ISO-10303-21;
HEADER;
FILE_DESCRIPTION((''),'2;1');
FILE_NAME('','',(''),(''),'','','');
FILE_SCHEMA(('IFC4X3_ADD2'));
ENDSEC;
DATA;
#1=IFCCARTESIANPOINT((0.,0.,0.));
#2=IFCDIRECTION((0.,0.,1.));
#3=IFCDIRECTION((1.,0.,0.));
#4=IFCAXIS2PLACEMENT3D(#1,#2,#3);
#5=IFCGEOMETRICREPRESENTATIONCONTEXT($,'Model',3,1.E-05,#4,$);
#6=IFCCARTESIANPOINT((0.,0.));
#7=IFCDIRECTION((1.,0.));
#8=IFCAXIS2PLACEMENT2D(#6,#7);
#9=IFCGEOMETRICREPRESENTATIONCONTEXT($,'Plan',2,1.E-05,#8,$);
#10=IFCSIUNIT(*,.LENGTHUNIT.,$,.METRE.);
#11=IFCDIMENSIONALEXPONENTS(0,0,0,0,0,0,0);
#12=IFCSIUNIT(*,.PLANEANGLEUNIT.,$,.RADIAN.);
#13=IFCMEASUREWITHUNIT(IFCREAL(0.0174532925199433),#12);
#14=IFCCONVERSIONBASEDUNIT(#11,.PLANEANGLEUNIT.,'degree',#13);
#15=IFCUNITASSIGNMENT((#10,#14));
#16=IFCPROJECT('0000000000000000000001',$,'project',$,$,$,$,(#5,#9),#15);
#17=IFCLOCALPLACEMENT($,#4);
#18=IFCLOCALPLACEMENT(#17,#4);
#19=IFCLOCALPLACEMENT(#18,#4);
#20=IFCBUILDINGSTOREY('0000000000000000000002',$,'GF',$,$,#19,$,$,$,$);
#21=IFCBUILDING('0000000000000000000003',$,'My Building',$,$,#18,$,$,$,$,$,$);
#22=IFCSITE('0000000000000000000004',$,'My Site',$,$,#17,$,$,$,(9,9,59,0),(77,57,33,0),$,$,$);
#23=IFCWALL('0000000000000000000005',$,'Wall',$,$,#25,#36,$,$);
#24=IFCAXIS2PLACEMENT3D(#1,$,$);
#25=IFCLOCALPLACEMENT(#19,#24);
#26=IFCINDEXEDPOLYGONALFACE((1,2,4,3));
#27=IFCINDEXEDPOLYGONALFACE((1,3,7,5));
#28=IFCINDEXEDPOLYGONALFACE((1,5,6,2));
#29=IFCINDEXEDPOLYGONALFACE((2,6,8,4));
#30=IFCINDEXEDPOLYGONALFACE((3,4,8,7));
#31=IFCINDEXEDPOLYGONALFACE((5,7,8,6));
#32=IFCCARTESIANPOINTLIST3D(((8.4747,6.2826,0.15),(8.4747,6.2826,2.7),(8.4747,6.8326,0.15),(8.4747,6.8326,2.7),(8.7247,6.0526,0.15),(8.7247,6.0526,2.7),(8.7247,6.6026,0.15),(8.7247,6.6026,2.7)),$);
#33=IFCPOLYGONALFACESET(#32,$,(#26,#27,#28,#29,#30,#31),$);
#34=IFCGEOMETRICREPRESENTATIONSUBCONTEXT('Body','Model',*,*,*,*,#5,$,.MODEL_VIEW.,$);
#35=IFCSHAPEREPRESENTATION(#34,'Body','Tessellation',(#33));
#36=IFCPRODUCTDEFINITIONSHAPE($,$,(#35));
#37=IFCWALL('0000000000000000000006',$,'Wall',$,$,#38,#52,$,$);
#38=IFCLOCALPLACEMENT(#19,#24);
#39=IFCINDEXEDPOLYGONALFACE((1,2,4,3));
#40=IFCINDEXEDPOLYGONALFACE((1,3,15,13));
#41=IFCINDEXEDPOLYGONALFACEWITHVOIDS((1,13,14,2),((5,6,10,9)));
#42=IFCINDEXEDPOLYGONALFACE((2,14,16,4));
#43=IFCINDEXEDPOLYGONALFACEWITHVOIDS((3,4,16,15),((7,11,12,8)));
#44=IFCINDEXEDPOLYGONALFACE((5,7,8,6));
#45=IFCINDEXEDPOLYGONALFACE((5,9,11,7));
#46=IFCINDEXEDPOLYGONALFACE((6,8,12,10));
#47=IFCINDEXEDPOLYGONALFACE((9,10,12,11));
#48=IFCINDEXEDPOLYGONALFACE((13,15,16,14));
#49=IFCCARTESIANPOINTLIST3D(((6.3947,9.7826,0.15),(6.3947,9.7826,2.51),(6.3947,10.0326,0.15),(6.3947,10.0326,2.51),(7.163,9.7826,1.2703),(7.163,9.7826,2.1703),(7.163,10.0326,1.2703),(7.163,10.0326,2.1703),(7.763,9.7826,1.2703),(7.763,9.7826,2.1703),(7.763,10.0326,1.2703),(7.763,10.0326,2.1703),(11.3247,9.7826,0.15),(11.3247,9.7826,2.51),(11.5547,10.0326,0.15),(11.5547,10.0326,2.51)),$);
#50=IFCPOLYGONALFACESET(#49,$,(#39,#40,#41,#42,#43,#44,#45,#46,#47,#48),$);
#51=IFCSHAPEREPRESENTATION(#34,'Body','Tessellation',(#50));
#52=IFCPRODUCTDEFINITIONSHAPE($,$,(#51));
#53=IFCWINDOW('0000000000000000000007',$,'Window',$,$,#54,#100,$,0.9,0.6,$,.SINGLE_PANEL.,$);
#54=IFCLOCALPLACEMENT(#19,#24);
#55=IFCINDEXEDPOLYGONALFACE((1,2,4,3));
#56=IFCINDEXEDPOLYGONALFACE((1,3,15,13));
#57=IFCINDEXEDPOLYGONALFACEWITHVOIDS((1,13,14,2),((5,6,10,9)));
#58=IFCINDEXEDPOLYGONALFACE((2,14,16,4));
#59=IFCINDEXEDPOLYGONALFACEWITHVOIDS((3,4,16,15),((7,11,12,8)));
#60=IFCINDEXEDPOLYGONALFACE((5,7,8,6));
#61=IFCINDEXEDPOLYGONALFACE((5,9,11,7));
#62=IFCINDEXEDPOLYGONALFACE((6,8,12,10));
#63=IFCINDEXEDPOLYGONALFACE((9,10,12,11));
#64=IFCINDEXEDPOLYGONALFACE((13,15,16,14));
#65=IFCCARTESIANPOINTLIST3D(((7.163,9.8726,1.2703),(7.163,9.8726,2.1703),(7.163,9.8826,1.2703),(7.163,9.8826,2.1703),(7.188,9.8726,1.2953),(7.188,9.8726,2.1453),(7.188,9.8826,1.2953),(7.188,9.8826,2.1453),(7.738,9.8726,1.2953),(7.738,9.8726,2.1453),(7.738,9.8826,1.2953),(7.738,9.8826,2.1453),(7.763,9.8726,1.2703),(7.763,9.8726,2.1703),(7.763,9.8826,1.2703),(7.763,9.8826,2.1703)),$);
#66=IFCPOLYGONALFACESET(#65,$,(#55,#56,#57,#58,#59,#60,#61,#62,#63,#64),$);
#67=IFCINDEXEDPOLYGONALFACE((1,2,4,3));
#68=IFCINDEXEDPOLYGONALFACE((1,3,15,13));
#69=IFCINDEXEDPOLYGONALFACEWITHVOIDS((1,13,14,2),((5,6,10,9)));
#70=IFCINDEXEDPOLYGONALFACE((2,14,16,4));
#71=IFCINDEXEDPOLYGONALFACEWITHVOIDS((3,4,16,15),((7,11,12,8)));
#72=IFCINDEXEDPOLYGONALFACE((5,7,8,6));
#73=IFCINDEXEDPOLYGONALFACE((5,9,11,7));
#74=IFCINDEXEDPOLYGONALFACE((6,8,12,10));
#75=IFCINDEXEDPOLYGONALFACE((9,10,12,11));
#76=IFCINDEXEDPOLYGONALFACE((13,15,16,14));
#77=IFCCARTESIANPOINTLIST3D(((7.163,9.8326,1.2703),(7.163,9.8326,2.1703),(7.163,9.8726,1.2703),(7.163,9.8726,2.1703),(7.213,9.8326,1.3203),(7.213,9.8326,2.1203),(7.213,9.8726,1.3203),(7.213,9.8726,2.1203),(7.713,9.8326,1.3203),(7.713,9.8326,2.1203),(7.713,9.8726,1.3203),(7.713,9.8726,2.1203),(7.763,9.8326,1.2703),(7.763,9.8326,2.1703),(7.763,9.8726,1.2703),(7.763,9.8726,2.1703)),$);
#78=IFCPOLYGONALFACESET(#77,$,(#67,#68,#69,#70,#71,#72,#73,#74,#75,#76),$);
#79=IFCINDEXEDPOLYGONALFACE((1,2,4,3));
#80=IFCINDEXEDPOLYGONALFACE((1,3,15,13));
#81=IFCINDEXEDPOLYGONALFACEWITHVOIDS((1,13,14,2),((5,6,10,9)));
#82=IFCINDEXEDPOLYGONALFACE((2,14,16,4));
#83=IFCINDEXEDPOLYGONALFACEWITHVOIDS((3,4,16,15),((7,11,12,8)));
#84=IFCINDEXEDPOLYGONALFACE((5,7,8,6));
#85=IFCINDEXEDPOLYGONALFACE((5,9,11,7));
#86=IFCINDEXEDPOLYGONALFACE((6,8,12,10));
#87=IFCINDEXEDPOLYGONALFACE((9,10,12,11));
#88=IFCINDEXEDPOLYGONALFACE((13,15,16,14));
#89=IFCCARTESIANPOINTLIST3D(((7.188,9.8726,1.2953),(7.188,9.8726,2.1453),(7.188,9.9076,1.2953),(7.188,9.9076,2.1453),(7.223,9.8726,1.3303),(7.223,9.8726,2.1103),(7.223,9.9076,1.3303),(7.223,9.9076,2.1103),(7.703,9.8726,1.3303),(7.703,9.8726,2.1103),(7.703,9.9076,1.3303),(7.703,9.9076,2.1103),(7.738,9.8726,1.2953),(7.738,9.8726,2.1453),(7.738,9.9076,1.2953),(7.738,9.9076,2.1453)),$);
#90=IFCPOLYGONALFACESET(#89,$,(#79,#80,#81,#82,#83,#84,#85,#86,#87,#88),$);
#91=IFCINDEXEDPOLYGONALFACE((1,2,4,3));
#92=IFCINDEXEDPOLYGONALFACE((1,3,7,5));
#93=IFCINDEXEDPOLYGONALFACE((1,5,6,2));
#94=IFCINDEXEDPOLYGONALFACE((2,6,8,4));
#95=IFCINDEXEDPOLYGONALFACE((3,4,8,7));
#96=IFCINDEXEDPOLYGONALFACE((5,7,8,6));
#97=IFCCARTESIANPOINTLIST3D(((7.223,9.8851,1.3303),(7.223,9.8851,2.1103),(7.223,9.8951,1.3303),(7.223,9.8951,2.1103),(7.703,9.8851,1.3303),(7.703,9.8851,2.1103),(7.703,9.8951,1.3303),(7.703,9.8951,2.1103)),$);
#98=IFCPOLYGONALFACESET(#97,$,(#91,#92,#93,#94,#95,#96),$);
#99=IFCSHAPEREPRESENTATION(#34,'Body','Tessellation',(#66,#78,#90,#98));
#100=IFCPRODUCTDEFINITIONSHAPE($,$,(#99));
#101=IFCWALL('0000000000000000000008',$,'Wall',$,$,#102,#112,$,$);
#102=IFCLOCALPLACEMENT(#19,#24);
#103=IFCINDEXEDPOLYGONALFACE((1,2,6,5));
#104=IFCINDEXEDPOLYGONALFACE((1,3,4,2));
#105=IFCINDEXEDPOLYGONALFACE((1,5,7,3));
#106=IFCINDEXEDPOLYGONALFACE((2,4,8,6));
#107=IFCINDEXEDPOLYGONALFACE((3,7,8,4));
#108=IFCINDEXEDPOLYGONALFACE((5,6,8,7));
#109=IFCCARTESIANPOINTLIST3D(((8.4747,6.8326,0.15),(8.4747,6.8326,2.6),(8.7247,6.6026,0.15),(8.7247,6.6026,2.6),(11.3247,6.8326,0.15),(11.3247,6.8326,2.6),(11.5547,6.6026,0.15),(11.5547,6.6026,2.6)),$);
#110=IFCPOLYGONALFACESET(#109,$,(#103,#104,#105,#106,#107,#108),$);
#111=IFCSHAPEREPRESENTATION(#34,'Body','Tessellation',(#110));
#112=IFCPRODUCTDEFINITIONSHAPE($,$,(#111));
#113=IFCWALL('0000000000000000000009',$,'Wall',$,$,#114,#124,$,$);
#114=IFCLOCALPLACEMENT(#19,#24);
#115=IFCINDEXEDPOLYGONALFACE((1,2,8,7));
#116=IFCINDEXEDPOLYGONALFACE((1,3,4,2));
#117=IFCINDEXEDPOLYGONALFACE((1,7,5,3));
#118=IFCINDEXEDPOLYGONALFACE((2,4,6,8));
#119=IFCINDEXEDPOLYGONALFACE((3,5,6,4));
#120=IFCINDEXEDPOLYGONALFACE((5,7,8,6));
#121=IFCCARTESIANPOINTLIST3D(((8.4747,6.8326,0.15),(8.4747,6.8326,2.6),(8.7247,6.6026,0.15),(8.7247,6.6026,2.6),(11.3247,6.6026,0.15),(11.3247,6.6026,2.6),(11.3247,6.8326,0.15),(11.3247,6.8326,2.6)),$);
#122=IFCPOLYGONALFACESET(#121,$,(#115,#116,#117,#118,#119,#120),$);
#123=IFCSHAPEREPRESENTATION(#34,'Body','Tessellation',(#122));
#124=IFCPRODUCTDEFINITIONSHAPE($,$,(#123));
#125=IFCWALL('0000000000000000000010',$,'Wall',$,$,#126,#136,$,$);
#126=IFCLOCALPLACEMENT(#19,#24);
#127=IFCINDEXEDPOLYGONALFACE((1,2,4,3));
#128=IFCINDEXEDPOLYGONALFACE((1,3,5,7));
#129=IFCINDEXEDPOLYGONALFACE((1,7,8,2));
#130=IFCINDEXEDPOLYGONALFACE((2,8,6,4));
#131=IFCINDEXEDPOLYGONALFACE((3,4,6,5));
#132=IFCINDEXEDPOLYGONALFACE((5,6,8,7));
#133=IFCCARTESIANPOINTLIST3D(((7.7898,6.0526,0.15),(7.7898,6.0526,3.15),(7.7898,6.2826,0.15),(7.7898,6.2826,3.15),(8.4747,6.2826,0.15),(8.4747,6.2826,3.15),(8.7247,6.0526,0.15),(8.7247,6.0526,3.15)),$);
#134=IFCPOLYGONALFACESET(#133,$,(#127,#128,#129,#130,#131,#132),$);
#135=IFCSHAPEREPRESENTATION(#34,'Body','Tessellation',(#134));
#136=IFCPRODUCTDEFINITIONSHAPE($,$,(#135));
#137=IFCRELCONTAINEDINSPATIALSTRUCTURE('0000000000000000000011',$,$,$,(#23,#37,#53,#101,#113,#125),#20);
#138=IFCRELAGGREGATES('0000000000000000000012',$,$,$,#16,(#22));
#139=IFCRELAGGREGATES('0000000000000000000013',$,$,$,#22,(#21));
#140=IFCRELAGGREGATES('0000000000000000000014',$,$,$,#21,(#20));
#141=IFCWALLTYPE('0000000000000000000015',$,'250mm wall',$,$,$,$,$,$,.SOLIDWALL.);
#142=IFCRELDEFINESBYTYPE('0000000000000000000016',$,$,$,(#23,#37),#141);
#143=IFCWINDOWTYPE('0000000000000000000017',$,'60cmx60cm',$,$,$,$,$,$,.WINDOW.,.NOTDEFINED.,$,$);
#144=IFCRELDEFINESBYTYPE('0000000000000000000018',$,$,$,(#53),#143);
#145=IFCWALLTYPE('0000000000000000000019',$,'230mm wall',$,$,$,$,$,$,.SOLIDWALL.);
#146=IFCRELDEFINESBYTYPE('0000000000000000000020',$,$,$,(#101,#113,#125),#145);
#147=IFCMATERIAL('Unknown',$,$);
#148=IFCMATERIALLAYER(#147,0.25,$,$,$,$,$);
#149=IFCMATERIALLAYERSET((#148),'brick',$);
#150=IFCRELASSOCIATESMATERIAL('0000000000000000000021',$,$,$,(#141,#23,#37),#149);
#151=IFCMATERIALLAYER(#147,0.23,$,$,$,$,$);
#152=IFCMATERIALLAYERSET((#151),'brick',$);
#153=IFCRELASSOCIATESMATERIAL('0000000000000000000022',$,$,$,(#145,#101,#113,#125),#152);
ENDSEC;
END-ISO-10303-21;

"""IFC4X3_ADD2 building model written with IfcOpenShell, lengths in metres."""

from ifc_helpers import new_model, entity, si_unit, converted_unit, frame, origin_with_axes, origin_2d_with_axis, place, context, subcontext, project, spatial, line, indexed_curve, outline, extrude, shape, source, transform, mapped, material, layer, layer_set, layer_usage, type_object, type_shapes, element, fill, save


model = new_model("IFC4X3_ADD2")

# Units and contexts
model_context = context("Model", 3, precision=1e-05, world=origin_with_axes())
plan_context = context("Plan", 2, precision=1e-05, world=origin_2d_with_axis())
body_context_1 = subcontext(model_context, "Body", "Model", "MODEL_VIEW")
body_context_2 = subcontext(plan_context, "Body", "Plan", "PLAN_VIEW")
ifc_project = project(units=[si_unit("LENGTHUNIT", "METRE"), converted_unit("PLANEANGLEUNIT", "degree", entity("IfcReal", 0.0174532925199433), si_unit("PLANEANGLEUNIT", "RADIAN"), dimensions=[0, 0, 0, 0, 0, 0, 0])], contexts=[model_context, plan_context])

# Site, building, storey
site_placement = place(None, origin_with_axes())
site = spatial("IfcSite", under=ifc_project, at=site_placement, Name="My Site", RefLatitude=(9, 9, 59, 0), RefLongitude=(77, 57, 33, 0))
building_placement = place(site_placement, origin_with_axes())
building = spatial("IfcBuilding", under=site, at=building_placement, Name="My Building")
storey_placement = place(building_placement, origin_with_axes())
storey = spatial("IfcBuildingStorey", under=building, at=storey_placement, Name="GF")

# Shared definitions
ifc_material = material(Name="Unknown")
ifc_layer_1 = layer(ifc_material, 0.25)
ifc_layer_set_1 = layer_set([ifc_layer_1], Name="brick")
wall_type_1 = type_object("IfcWallType", Name="250mm wall", PredefinedType="SOLIDWALL", material=ifc_layer_set_1)
wall_1_placement = place(storey_placement, frame((6.3947, 9.7826, 0.15), z_axis=(0.0, 0.0, 1.0), x_axis=(1.0, 0.0, 0.0)))
shared_shape_1 = source(origin_with_axes(), body_context_1, "Body", "SweptSolid", [
    extrude(outline(indexed_curve([(0.0, 0.0), (0.6, 0.0), (0.6, 0.9), (0.0, 0.9)], segments=[line(1, 2, 3, 4, 1)])), frame((0.0, -0.6, 0.0), z_axis=(0.0, -1.0, 0.0), x_axis=(1.0, 0.0, 0.0)), (0.0, 0.0, -1.0), 1.2),
])
window_type_1 = type_object("IfcWindowType", Name="60cmx60cm", PartitioningType="NOTDEFINED", PredefinedType="WINDOW")
shared_shape_2 = source(origin_with_axes(), body_context_1, "Body", "SweptSolid", [
    extrude(outline(indexed_curve([(0.0, 0.0), (0.6, 0.0), (0.6, 0.9), (0.0, 0.9)], segments=[line(1, 2, 3, 4, 1)]), holes=[indexed_curve([(0.025, 0.025), (0.575, 0.025), (0.575, 0.875), (0.025, 0.875)], segments=[line(1, 2, 3, 4, 1)])]), frame((0.0, 0.09, 0.0), z_axis=(0.0, -1.0, 0.0), x_axis=(1.0, 0.0, 0.0)), (0.0, 0.0, -1.0), 0.01),
    extrude(outline(indexed_curve([(0.0, 0.0), (0.6, 0.0), (0.6, 0.9), (0.0, 0.9)], segments=[line(1, 2, 3, 4, 1)]), holes=[indexed_curve([(0.05, 0.05), (0.55, 0.05), (0.55, 0.85), (0.05, 0.85)], segments=[line(1, 2, 3, 4, 1)])]), frame((0.0, 0.05, 0.0), z_axis=(0.0, -1.0, 0.0), x_axis=(1.0, 0.0, 0.0)), (0.0, 0.0, -1.0), 0.04),
    extrude(outline(indexed_curve([(0.0, 0.0), (0.55, 0.0), (0.55, 0.85), (0.0, 0.85)], segments=[line(1, 2, 3, 4, 1)]), holes=[indexed_curve([(0.035, 0.035), (0.515, 0.035), (0.515, 0.815), (0.035, 0.815)], segments=[line(1, 2, 3, 4, 1)])]), frame((0.025, 0.09, 0.025), z_axis=(0.0, -1.0, 0.0), x_axis=(1.0, 0.0, 0.0)), (0.0, 0.0, -1.0), 0.035),
    extrude(outline(indexed_curve([(0.035, 0.035), (0.515, 0.035), (0.515, 0.815), (0.035, 0.815)], segments=[line(1, 2, 3, 4, 1)])), frame((0.025, 0.1025, 0.025), z_axis=(0.0, -1.0, 0.0), x_axis=(1.0, 0.0, 0.0)), (0.0, 0.0, -1.0), 0.01),
])
shared_shape_3 = source(origin_with_axes(), body_context_2, "Body", "Curve2D", [
    entity("IfcIndexedPolyCurve", entity("IfcCartesianPointList2D", [[0.05, 0.05], [0.55, 0.05]])),
    entity("IfcIndexedPolyCurve", entity("IfcCartesianPointList2D", [[0.0, 0.1], [0.025, 0.1], [0.025, 0.09], [0.05, 0.09], [0.05, 0.05], [0.0, 0.05]]), [entity("IfcLineIndex", [1, 2, 3, 4, 5, 6, 1])]),
    entity("IfcIndexedPolyCurve", entity("IfcCartesianPointList2D", [[0.6, 0.1], [0.575, 0.1], [0.575, 0.09], [0.55, 0.09], [0.55, 0.05], [0.6, 0.05]]), [entity("IfcLineIndex", [1, 2, 3, 4, 5, 6, 1])]),
    entity("IfcIndexedPolyCurve", entity("IfcCartesianPointList2D", [[0.025, 0.09], [0.06, 0.09], [0.06, 0.125], [0.025, 0.125]]), [entity("IfcLineIndex", [1, 2, 3, 4, 1])]),
    entity("IfcIndexedPolyCurve", entity("IfcCartesianPointList2D", [[0.575, 0.09], [0.54, 0.09], [0.54, 0.125], [0.575, 0.125]]), [entity("IfcLineIndex", [1, 2, 3, 4, 1])]),
    entity("IfcIndexedPolyCurve", entity("IfcCartesianPointList2D", [[0.06, 0.09], [0.54, 0.09]])),
    entity("IfcIndexedPolyCurve", entity("IfcCartesianPointList2D", [[0.06, 0.125], [0.54, 0.125]])),
    entity("IfcIndexedPolyCurve", entity("IfcCartesianPointList2D", [[0.06, 0.1075], [0.54, 0.1075]])),
])
type_shapes(window_type_1, [shared_shape_2, shared_shape_3])
placement = place(wall_1_placement, frame((0.7684, 0.0, 1.1203), z_axis=(0.0, 0.0, 1.0), x_axis=(1.0, 0.0, 0.0)))

# Wall
ifc_layer_usage_1 = layer_usage(ifc_layer_set_1, "AXIS2", "POSITIVE", 0.0)
wall_2_placement = place(storey_placement, frame((8.7247, 6.0526, 0.15), z_axis=(0.0, 0.0, 1.0), x_axis=(0.0, 1.0, 0.0)))
element("IfcWall", 1, at=wall_2_placement, inside=storey, type_object=wall_type_1, material=ifc_layer_usage_1, Name="Wall", context=body_context_1, shape_type="SweptSolid", body=[
    extrude(outline(indexed_curve([(0.0, 0.0), (0.23, 0.25), (0.78, 0.25), (0.55, 0.0)], segments=[line(1, 2, 3, 4, 1)])), origin_with_axes(), (0.0, 0.0, 1.0), 2.55),
])

# Wall, opening, window
ifc_layer_usage_2 = layer_usage(ifc_layer_set_1, "AXIS2", "POSITIVE", 0.0)
wall_3_placement = place(storey_placement, frame((6.3947, 9.7826, 0.15), z_axis=(0.0, 0.0, 1.0), x_axis=(1.0, 0.0, 0.0)))
wall_3 = element("IfcWall", 2, at=wall_3_placement, inside=storey, type_object=wall_type_1, material=ifc_layer_usage_2, Name="Wall", context=body_context_1, shape_type="SweptSolid", body=[
    extrude(outline(indexed_curve([(0.0, 0.0), (0.0, 0.25), (5.16, 0.25), (4.93, 0.0)], segments=[line(1, 2, 3, 4, 1)])), origin_with_axes(), (0.0, 0.0, 1.0), 2.36),
])
opening_1_placement = place(wall_3_placement, frame((0.7684, 0.0, 1.1203), z_axis=(0.0, 0.0, 1.0), x_axis=(1.0, 0.0, 0.0)))
opening_1 = element("IfcOpeningElement", 3, at=opening_1_placement, cuts=wall_3, PredefinedType="OPENING", context=body_context_1, shape_type="MappedRepresentation", body=[
    mapped(shared_shape_1, transform((0.0, 0.0, 0.0), x_axis=(1.0, 0.0, 0.0), y_axis=(0.0, 1.0, 0.0), z_axis=(0.0, 0.0, 1.0), scale=1.0)),
])
window_1_placement = place(placement, origin_with_axes())
window_1 = element("IfcWindow", 4, at=window_1_placement, inside=storey, type_object=window_type_1, Name="Window", OverallHeight=0.9, OverallWidth=0.6, PartitioningType="SINGLE_PANEL", shapes=[
    shape(body_context_1, "Body", "MappedRepresentation", [mapped(shared_shape_2, transform((0.0, 0.0, 0.0), x_axis=(1.0, 0.0, 0.0), y_axis=(0.0, 1.0, 0.0), z_axis=(0.0, 0.0, 1.0), scale=1.0))]),
    shape(body_context_2, "Body", "MappedRepresentation", [mapped(shared_shape_3, transform((0.0, 0.0, 0.0), x_axis=(1.0, 0.0, 0.0), y_axis=(0.0, 1.0, 0.0), z_axis=(0.0, 0.0, 1.0), scale=1.0))]),
])
fill(opening_1, window_1)

# Walls
ifc_layer_2 = layer(ifc_material, 0.23)
ifc_layer_set_2 = layer_set([ifc_layer_2], Name="brick")
ifc_layer_usage_3 = layer_usage(ifc_layer_set_2, "AXIS2", "POSITIVE", 0.0)
wall_type_2 = type_object("IfcWallType", Name="230mm wall", PredefinedType="SOLIDWALL", material=ifc_layer_set_2)
wall_4_placement = place(storey_placement, frame((8.7247, 6.6026, 0.15), z_axis=(0.0, 0.0, 1.0), x_axis=(1.0, 0.0, 0.0)))
element("IfcWall", 5, at=wall_4_placement, inside=storey, type_object=wall_type_2, material=ifc_layer_usage_3, Name="Wall", context=body_context_1, shape_type="SweptSolid", body=[
    extrude(outline(indexed_curve([(0.0, 0.0), (-0.25, 0.23), (2.6, 0.23), (2.83, 0.0)], segments=[line(1, 2, 3, 4, 1)])), origin_with_axes(), (0.0, 0.0, 1.0), 2.45),
])
ifc_layer_usage_4 = layer_usage(ifc_layer_set_2, "AXIS2", "POSITIVE", 0.0)
wall_5_placement = place(storey_placement, frame((8.7247, 6.6026, 0.15), z_axis=(0.0, 0.0, 1.0), x_axis=(1.0, 0.0, 0.0)))
element("IfcWall", 6, at=wall_5_placement, inside=storey, type_object=wall_type_2, material=ifc_layer_usage_4, Name="Wall", context=body_context_1, shape_type="SweptSolid", body=[
    extrude(outline(indexed_curve([(0.0, 0.0), (-0.25, 0.23), (2.6, 0.23), (2.6, 0.0)], segments=[line(1, 2, 3, 4, 1)])), origin_with_axes(), (0.0, 0.0, 1.0), 2.45),
])
ifc_layer_usage_5 = layer_usage(ifc_layer_set_2, "AXIS2", "POSITIVE", 0.0)
wall_6_placement = place(storey_placement, frame((7.7898, 6.0526, 0.15), z_axis=(0.0, 0.0, 1.0), x_axis=(1.0, 0.0, 0.0)))
element("IfcWall", 7, at=wall_6_placement, inside=storey, type_object=wall_type_2, material=ifc_layer_usage_5, Name="Wall", context=body_context_1, shape_type="SweptSolid", body=[
    extrude(outline(indexed_curve([(0.0, 0.0), (0.0, 0.23), (0.6849, 0.23), (0.9349, 0.0)], segments=[line(1, 2, 3, 4, 1)])), origin_with_axes(), (0.0, 0.0, 1.0), 3.0),
])

save(model, "model.ifc")
